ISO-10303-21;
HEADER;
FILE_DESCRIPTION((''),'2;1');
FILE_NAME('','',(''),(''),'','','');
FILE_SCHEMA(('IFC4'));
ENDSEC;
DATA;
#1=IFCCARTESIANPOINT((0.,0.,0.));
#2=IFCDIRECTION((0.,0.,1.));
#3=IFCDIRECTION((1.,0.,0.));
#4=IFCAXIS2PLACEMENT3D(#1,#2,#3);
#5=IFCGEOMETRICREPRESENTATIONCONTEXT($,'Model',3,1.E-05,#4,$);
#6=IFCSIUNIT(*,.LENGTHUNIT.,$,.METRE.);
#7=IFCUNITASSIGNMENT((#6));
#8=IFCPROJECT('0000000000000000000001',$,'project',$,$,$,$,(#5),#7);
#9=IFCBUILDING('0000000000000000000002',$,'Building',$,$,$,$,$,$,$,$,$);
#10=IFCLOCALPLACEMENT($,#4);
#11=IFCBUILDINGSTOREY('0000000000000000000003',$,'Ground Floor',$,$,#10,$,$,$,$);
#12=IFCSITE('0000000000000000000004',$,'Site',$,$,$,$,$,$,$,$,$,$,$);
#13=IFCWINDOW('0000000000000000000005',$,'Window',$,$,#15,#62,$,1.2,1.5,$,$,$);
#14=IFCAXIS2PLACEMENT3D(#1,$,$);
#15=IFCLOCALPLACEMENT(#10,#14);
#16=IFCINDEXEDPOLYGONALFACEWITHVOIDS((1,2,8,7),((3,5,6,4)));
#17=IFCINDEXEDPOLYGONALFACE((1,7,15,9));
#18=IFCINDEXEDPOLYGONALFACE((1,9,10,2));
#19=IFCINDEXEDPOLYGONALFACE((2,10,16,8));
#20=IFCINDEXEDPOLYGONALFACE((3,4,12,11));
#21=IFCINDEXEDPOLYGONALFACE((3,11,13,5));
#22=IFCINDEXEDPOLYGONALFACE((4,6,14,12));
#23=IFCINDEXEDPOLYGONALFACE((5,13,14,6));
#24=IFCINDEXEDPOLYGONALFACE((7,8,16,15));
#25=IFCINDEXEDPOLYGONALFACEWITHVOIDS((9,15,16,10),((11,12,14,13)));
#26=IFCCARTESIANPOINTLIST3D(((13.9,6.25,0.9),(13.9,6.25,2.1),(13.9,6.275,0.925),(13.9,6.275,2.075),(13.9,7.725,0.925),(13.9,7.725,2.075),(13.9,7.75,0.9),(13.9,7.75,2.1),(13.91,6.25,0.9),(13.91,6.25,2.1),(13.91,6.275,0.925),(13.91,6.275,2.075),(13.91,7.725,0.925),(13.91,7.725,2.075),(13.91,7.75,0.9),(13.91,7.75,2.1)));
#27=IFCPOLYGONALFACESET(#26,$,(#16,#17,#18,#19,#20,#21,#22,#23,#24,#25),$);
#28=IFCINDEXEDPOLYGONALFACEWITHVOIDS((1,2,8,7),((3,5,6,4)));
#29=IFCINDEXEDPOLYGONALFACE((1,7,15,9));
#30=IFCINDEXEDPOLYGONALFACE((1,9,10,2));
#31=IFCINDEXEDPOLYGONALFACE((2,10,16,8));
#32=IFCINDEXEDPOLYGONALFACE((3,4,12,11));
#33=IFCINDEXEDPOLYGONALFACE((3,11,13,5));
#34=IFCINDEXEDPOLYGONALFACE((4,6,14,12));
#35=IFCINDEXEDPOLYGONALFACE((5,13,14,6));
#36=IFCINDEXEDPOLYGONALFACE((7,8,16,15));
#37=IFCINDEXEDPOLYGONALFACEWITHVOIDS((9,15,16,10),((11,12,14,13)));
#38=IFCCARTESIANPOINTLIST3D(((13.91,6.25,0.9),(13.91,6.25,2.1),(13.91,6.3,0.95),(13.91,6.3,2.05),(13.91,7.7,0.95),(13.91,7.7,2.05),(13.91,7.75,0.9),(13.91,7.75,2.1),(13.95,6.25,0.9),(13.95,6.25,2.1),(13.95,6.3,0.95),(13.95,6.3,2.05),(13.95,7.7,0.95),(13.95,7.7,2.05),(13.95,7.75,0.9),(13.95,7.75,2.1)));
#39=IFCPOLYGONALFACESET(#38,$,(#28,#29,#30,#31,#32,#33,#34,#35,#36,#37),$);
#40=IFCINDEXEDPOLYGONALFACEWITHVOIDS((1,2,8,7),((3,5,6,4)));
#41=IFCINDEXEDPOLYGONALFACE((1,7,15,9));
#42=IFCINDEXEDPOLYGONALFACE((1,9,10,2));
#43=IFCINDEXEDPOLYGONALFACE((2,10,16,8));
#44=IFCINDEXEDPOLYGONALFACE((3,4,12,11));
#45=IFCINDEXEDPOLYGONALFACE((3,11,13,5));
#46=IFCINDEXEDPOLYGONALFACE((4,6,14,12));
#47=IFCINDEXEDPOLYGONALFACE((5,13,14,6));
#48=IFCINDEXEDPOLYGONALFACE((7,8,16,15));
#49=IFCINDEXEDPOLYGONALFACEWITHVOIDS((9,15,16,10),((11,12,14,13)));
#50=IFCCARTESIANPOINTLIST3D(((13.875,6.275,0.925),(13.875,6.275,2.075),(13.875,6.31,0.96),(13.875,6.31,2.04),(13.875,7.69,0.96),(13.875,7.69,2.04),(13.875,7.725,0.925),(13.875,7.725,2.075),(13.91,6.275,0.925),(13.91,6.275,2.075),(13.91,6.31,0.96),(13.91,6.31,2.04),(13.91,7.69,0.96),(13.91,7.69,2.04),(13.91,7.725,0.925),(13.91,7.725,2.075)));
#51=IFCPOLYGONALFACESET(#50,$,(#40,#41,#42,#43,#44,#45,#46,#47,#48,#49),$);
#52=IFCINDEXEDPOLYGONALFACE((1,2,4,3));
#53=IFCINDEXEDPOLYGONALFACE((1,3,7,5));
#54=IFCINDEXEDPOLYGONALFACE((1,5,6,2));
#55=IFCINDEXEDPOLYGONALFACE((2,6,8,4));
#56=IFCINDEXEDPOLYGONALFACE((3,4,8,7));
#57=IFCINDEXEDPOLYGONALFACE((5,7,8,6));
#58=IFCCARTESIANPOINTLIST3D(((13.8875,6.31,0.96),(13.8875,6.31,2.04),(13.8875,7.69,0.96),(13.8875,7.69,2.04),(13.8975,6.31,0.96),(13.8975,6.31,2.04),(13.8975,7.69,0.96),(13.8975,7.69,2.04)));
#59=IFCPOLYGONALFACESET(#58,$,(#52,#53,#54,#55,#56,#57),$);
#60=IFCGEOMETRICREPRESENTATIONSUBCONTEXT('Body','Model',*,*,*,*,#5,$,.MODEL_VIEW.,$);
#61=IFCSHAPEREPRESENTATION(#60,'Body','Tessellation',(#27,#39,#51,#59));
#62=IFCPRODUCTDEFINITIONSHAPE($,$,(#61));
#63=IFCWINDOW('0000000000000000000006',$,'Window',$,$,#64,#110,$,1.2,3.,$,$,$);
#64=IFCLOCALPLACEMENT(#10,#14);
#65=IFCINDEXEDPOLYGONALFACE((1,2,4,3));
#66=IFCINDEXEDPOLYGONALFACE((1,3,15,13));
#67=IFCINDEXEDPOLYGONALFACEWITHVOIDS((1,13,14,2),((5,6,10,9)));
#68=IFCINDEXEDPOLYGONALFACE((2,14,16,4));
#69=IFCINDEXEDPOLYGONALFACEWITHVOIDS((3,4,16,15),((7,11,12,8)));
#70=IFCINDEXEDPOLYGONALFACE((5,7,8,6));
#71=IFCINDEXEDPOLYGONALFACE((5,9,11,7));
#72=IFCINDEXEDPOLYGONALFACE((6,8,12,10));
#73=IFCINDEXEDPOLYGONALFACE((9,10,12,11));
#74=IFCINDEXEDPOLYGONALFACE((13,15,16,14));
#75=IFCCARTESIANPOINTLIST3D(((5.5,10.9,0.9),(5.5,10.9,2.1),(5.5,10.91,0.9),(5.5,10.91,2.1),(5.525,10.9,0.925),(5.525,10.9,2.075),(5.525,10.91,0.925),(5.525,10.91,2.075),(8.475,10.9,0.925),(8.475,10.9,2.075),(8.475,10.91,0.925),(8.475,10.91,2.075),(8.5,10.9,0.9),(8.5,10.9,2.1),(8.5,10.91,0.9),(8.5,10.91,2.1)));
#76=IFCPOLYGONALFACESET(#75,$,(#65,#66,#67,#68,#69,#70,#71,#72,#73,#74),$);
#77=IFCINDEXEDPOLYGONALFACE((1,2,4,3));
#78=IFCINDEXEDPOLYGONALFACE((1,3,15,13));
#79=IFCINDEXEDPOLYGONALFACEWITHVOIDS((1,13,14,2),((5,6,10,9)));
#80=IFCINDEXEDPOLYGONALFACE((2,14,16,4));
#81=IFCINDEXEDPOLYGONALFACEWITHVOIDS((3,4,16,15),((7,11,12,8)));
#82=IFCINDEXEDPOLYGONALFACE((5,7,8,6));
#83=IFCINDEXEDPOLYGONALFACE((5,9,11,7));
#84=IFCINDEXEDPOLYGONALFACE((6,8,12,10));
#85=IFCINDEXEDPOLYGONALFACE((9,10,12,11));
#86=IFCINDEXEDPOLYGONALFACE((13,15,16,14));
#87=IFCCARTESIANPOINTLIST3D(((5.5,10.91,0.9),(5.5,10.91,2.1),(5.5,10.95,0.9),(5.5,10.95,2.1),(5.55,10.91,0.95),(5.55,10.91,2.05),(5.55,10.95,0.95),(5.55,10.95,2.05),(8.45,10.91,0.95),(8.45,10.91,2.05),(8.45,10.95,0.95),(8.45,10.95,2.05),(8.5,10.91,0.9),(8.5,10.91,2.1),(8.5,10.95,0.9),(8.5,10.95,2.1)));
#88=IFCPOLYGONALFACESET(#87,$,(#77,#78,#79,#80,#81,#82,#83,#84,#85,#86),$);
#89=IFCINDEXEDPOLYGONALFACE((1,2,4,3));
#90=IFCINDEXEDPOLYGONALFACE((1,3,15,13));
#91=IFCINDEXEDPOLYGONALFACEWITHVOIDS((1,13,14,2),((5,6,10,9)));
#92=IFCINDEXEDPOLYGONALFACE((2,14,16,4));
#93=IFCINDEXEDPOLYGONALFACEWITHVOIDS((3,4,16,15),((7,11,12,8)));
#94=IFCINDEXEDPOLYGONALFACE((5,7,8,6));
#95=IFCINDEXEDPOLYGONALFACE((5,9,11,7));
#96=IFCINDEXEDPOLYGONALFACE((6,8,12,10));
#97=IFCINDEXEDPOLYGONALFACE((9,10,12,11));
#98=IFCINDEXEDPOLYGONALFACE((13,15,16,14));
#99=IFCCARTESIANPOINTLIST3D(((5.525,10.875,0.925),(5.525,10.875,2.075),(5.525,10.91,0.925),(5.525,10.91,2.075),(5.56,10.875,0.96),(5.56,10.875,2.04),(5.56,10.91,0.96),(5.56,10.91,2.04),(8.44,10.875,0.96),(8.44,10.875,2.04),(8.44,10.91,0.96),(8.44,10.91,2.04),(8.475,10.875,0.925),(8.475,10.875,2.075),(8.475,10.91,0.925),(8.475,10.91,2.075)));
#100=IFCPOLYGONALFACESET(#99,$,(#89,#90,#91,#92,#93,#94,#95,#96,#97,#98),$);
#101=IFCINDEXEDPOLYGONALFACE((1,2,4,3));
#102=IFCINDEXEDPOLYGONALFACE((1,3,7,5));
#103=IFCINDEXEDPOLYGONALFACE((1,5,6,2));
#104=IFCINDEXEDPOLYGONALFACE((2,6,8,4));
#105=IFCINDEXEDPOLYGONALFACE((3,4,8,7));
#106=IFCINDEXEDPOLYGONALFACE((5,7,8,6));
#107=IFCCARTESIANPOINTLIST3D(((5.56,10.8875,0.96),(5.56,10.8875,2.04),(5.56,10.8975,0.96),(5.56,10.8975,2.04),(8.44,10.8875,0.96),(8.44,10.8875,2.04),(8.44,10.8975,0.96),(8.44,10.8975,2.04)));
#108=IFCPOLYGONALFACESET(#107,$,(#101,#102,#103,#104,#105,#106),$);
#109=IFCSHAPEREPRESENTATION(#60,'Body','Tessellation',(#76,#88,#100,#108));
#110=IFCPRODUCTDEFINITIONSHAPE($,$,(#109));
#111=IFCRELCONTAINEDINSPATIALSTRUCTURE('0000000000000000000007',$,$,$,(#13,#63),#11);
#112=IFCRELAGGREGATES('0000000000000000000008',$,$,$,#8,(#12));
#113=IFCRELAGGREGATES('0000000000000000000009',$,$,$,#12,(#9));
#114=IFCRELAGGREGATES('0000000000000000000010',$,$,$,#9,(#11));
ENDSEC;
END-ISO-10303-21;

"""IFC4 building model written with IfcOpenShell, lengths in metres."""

from ifc_helpers import new_model, si_unit, frame, origin_with_axes, place, context, subcontext, project, spatial, line, indexed_curve, outline, extrude, element, save


model = new_model("IFC4")

# Units and contexts
model_context = context("Model", 3, precision=1e-05, world=origin_with_axes())
body_context = subcontext(model_context, "Body", "Model", "MODEL_VIEW")
ifc_project = project(units=[si_unit("LENGTHUNIT", "METRE")], contexts=[model_context])

# Site, building, storey
site = spatial("IfcSite", under=ifc_project, Name="Site")
building = spatial("IfcBuilding", under=site, Name="Building")
storey_placement = place(None, origin_with_axes())
storey = spatial("IfcBuildingStorey", under=building, at=storey_placement, Name="Ground Floor")

# Windows
for number, where, z_axis, x_axis, name in (
    (1, (14.0, 6.25, 0.9), (0.0, 0.0, 1.0), (0.0, 1.0, 0.0), "Window"),
):
    element("IfcWindow", number, at=place(storey_placement, frame(where, z_axis=z_axis, x_axis=x_axis)), inside=storey, Name=name, OverallHeight=1.2, OverallWidth=1.5, context=body_context, shape_type="SweptSolid", body=[
        extrude(outline(indexed_curve([(0.0, 0.0), (1.5, 0.0), (1.5, 1.2), (0.0, 1.2)], segments=[line(1, 2, 3, 4, 1)]), holes=[indexed_curve([(0.025, 0.025), (1.475, 0.025), (1.475, 1.175), (0.025, 1.175)], segments=[line(1, 2, 3, 4, 1)])]), frame((0.0, 0.09, 0.0), z_axis=(0.0, -1.0, 0.0), x_axis=(1.0, 0.0, 0.0)), (0.0, 0.0, -1.0), 0.01),
        extrude(outline(indexed_curve([(0.0, 0.0), (1.5, 0.0), (1.5, 1.2), (0.0, 1.2)], segments=[line(1, 2, 3, 4, 1)]), holes=[indexed_curve([(0.05, 0.05), (1.45, 0.05), (1.45, 1.15), (0.05, 1.15)], segments=[line(1, 2, 3, 4, 1)])]), frame((0.0, 0.05, 0.0), z_axis=(0.0, -1.0, 0.0), x_axis=(1.0, 0.0, 0.0)), (0.0, 0.0, -1.0), 0.04),
        extrude(outline(indexed_curve([(0.0, 0.0), (1.45, 0.0), (1.45, 1.15), (0.0, 1.15)], segments=[line(1, 2, 3, 4, 1)]), holes=[indexed_curve([(0.035, 0.035), (1.415, 0.035), (1.415, 1.115), (0.035, 1.115)], segments=[line(1, 2, 3, 4, 1)])]), frame((0.025, 0.09, 0.025), z_axis=(0.0, -1.0, 0.0), x_axis=(1.0, 0.0, 0.0)), (0.0, 0.0, -1.0), 0.035),
        extrude(outline(indexed_curve([(0.035, 0.035), (1.415, 0.035), (1.415, 1.115), (0.035, 1.115)], segments=[line(1, 2, 3, 4, 1)])), frame((0.025, 0.1025, 0.025), z_axis=(0.0, -1.0, 0.0), x_axis=(1.0, 0.0, 0.0)), (0.0, 0.0, -1.0), 0.01),
    ])
window_placement = place(storey_placement, frame((8.5, 11.0, 0.9), z_axis=(0.0, 0.0, 1.0), x_axis=(-1.0, 0.0, 0.0)))
element("IfcWindow", 2, at=window_placement, inside=storey, Name="Window", OverallHeight=1.2, OverallWidth=3.0, context=body_context, shape_type="SweptSolid", body=[
    extrude(outline(indexed_curve([(0.0, 0.0), (3.0, 0.0), (3.0, 1.2), (0.0, 1.2)], segments=[line(1, 2, 3, 4, 1)]), holes=[indexed_curve([(0.025, 0.025), (2.975, 0.025), (2.975, 1.175), (0.025, 1.175)], segments=[line(1, 2, 3, 4, 1)])]), frame((0.0, 0.09, 0.0), z_axis=(0.0, -1.0, 0.0), x_axis=(1.0, 0.0, 0.0)), (0.0, 0.0, -1.0), 0.01),
    extrude(outline(indexed_curve([(0.0, 0.0), (3.0, 0.0), (3.0, 1.2), (0.0, 1.2)], segments=[line(1, 2, 3, 4, 1)]), holes=[indexed_curve([(0.05, 0.05), (2.95, 0.05), (2.95, 1.15), (0.05, 1.15)], segments=[line(1, 2, 3, 4, 1)])]), frame((0.0, 0.05, 0.0), z_axis=(0.0, -1.0, 0.0), x_axis=(1.0, 0.0, 0.0)), (0.0, 0.0, -1.0), 0.04),
    extrude(outline(indexed_curve([(0.0, 0.0), (2.95, 0.0), (2.95, 1.15), (0.0, 1.15)], segments=[line(1, 2, 3, 4, 1)]), holes=[indexed_curve([(0.035, 0.035), (2.915, 0.035), (2.915, 1.115), (0.035, 1.115)], segments=[line(1, 2, 3, 4, 1)])]), frame((0.025, 0.09, 0.025), z_axis=(0.0, -1.0, 0.0), x_axis=(1.0, 0.0, 0.0)), (0.0, 0.0, -1.0), 0.035),
    extrude(outline(indexed_curve([(0.035, 0.035), (2.915, 0.035), (2.915, 1.115), (0.035, 1.115)], segments=[line(1, 2, 3, 4, 1)])), frame((0.025, 0.1025, 0.025), z_axis=(0.0, -1.0, 0.0), x_axis=(1.0, 0.0, 0.0)), (0.0, 0.0, -1.0), 0.01),
])

save(model, "model.ifc")
